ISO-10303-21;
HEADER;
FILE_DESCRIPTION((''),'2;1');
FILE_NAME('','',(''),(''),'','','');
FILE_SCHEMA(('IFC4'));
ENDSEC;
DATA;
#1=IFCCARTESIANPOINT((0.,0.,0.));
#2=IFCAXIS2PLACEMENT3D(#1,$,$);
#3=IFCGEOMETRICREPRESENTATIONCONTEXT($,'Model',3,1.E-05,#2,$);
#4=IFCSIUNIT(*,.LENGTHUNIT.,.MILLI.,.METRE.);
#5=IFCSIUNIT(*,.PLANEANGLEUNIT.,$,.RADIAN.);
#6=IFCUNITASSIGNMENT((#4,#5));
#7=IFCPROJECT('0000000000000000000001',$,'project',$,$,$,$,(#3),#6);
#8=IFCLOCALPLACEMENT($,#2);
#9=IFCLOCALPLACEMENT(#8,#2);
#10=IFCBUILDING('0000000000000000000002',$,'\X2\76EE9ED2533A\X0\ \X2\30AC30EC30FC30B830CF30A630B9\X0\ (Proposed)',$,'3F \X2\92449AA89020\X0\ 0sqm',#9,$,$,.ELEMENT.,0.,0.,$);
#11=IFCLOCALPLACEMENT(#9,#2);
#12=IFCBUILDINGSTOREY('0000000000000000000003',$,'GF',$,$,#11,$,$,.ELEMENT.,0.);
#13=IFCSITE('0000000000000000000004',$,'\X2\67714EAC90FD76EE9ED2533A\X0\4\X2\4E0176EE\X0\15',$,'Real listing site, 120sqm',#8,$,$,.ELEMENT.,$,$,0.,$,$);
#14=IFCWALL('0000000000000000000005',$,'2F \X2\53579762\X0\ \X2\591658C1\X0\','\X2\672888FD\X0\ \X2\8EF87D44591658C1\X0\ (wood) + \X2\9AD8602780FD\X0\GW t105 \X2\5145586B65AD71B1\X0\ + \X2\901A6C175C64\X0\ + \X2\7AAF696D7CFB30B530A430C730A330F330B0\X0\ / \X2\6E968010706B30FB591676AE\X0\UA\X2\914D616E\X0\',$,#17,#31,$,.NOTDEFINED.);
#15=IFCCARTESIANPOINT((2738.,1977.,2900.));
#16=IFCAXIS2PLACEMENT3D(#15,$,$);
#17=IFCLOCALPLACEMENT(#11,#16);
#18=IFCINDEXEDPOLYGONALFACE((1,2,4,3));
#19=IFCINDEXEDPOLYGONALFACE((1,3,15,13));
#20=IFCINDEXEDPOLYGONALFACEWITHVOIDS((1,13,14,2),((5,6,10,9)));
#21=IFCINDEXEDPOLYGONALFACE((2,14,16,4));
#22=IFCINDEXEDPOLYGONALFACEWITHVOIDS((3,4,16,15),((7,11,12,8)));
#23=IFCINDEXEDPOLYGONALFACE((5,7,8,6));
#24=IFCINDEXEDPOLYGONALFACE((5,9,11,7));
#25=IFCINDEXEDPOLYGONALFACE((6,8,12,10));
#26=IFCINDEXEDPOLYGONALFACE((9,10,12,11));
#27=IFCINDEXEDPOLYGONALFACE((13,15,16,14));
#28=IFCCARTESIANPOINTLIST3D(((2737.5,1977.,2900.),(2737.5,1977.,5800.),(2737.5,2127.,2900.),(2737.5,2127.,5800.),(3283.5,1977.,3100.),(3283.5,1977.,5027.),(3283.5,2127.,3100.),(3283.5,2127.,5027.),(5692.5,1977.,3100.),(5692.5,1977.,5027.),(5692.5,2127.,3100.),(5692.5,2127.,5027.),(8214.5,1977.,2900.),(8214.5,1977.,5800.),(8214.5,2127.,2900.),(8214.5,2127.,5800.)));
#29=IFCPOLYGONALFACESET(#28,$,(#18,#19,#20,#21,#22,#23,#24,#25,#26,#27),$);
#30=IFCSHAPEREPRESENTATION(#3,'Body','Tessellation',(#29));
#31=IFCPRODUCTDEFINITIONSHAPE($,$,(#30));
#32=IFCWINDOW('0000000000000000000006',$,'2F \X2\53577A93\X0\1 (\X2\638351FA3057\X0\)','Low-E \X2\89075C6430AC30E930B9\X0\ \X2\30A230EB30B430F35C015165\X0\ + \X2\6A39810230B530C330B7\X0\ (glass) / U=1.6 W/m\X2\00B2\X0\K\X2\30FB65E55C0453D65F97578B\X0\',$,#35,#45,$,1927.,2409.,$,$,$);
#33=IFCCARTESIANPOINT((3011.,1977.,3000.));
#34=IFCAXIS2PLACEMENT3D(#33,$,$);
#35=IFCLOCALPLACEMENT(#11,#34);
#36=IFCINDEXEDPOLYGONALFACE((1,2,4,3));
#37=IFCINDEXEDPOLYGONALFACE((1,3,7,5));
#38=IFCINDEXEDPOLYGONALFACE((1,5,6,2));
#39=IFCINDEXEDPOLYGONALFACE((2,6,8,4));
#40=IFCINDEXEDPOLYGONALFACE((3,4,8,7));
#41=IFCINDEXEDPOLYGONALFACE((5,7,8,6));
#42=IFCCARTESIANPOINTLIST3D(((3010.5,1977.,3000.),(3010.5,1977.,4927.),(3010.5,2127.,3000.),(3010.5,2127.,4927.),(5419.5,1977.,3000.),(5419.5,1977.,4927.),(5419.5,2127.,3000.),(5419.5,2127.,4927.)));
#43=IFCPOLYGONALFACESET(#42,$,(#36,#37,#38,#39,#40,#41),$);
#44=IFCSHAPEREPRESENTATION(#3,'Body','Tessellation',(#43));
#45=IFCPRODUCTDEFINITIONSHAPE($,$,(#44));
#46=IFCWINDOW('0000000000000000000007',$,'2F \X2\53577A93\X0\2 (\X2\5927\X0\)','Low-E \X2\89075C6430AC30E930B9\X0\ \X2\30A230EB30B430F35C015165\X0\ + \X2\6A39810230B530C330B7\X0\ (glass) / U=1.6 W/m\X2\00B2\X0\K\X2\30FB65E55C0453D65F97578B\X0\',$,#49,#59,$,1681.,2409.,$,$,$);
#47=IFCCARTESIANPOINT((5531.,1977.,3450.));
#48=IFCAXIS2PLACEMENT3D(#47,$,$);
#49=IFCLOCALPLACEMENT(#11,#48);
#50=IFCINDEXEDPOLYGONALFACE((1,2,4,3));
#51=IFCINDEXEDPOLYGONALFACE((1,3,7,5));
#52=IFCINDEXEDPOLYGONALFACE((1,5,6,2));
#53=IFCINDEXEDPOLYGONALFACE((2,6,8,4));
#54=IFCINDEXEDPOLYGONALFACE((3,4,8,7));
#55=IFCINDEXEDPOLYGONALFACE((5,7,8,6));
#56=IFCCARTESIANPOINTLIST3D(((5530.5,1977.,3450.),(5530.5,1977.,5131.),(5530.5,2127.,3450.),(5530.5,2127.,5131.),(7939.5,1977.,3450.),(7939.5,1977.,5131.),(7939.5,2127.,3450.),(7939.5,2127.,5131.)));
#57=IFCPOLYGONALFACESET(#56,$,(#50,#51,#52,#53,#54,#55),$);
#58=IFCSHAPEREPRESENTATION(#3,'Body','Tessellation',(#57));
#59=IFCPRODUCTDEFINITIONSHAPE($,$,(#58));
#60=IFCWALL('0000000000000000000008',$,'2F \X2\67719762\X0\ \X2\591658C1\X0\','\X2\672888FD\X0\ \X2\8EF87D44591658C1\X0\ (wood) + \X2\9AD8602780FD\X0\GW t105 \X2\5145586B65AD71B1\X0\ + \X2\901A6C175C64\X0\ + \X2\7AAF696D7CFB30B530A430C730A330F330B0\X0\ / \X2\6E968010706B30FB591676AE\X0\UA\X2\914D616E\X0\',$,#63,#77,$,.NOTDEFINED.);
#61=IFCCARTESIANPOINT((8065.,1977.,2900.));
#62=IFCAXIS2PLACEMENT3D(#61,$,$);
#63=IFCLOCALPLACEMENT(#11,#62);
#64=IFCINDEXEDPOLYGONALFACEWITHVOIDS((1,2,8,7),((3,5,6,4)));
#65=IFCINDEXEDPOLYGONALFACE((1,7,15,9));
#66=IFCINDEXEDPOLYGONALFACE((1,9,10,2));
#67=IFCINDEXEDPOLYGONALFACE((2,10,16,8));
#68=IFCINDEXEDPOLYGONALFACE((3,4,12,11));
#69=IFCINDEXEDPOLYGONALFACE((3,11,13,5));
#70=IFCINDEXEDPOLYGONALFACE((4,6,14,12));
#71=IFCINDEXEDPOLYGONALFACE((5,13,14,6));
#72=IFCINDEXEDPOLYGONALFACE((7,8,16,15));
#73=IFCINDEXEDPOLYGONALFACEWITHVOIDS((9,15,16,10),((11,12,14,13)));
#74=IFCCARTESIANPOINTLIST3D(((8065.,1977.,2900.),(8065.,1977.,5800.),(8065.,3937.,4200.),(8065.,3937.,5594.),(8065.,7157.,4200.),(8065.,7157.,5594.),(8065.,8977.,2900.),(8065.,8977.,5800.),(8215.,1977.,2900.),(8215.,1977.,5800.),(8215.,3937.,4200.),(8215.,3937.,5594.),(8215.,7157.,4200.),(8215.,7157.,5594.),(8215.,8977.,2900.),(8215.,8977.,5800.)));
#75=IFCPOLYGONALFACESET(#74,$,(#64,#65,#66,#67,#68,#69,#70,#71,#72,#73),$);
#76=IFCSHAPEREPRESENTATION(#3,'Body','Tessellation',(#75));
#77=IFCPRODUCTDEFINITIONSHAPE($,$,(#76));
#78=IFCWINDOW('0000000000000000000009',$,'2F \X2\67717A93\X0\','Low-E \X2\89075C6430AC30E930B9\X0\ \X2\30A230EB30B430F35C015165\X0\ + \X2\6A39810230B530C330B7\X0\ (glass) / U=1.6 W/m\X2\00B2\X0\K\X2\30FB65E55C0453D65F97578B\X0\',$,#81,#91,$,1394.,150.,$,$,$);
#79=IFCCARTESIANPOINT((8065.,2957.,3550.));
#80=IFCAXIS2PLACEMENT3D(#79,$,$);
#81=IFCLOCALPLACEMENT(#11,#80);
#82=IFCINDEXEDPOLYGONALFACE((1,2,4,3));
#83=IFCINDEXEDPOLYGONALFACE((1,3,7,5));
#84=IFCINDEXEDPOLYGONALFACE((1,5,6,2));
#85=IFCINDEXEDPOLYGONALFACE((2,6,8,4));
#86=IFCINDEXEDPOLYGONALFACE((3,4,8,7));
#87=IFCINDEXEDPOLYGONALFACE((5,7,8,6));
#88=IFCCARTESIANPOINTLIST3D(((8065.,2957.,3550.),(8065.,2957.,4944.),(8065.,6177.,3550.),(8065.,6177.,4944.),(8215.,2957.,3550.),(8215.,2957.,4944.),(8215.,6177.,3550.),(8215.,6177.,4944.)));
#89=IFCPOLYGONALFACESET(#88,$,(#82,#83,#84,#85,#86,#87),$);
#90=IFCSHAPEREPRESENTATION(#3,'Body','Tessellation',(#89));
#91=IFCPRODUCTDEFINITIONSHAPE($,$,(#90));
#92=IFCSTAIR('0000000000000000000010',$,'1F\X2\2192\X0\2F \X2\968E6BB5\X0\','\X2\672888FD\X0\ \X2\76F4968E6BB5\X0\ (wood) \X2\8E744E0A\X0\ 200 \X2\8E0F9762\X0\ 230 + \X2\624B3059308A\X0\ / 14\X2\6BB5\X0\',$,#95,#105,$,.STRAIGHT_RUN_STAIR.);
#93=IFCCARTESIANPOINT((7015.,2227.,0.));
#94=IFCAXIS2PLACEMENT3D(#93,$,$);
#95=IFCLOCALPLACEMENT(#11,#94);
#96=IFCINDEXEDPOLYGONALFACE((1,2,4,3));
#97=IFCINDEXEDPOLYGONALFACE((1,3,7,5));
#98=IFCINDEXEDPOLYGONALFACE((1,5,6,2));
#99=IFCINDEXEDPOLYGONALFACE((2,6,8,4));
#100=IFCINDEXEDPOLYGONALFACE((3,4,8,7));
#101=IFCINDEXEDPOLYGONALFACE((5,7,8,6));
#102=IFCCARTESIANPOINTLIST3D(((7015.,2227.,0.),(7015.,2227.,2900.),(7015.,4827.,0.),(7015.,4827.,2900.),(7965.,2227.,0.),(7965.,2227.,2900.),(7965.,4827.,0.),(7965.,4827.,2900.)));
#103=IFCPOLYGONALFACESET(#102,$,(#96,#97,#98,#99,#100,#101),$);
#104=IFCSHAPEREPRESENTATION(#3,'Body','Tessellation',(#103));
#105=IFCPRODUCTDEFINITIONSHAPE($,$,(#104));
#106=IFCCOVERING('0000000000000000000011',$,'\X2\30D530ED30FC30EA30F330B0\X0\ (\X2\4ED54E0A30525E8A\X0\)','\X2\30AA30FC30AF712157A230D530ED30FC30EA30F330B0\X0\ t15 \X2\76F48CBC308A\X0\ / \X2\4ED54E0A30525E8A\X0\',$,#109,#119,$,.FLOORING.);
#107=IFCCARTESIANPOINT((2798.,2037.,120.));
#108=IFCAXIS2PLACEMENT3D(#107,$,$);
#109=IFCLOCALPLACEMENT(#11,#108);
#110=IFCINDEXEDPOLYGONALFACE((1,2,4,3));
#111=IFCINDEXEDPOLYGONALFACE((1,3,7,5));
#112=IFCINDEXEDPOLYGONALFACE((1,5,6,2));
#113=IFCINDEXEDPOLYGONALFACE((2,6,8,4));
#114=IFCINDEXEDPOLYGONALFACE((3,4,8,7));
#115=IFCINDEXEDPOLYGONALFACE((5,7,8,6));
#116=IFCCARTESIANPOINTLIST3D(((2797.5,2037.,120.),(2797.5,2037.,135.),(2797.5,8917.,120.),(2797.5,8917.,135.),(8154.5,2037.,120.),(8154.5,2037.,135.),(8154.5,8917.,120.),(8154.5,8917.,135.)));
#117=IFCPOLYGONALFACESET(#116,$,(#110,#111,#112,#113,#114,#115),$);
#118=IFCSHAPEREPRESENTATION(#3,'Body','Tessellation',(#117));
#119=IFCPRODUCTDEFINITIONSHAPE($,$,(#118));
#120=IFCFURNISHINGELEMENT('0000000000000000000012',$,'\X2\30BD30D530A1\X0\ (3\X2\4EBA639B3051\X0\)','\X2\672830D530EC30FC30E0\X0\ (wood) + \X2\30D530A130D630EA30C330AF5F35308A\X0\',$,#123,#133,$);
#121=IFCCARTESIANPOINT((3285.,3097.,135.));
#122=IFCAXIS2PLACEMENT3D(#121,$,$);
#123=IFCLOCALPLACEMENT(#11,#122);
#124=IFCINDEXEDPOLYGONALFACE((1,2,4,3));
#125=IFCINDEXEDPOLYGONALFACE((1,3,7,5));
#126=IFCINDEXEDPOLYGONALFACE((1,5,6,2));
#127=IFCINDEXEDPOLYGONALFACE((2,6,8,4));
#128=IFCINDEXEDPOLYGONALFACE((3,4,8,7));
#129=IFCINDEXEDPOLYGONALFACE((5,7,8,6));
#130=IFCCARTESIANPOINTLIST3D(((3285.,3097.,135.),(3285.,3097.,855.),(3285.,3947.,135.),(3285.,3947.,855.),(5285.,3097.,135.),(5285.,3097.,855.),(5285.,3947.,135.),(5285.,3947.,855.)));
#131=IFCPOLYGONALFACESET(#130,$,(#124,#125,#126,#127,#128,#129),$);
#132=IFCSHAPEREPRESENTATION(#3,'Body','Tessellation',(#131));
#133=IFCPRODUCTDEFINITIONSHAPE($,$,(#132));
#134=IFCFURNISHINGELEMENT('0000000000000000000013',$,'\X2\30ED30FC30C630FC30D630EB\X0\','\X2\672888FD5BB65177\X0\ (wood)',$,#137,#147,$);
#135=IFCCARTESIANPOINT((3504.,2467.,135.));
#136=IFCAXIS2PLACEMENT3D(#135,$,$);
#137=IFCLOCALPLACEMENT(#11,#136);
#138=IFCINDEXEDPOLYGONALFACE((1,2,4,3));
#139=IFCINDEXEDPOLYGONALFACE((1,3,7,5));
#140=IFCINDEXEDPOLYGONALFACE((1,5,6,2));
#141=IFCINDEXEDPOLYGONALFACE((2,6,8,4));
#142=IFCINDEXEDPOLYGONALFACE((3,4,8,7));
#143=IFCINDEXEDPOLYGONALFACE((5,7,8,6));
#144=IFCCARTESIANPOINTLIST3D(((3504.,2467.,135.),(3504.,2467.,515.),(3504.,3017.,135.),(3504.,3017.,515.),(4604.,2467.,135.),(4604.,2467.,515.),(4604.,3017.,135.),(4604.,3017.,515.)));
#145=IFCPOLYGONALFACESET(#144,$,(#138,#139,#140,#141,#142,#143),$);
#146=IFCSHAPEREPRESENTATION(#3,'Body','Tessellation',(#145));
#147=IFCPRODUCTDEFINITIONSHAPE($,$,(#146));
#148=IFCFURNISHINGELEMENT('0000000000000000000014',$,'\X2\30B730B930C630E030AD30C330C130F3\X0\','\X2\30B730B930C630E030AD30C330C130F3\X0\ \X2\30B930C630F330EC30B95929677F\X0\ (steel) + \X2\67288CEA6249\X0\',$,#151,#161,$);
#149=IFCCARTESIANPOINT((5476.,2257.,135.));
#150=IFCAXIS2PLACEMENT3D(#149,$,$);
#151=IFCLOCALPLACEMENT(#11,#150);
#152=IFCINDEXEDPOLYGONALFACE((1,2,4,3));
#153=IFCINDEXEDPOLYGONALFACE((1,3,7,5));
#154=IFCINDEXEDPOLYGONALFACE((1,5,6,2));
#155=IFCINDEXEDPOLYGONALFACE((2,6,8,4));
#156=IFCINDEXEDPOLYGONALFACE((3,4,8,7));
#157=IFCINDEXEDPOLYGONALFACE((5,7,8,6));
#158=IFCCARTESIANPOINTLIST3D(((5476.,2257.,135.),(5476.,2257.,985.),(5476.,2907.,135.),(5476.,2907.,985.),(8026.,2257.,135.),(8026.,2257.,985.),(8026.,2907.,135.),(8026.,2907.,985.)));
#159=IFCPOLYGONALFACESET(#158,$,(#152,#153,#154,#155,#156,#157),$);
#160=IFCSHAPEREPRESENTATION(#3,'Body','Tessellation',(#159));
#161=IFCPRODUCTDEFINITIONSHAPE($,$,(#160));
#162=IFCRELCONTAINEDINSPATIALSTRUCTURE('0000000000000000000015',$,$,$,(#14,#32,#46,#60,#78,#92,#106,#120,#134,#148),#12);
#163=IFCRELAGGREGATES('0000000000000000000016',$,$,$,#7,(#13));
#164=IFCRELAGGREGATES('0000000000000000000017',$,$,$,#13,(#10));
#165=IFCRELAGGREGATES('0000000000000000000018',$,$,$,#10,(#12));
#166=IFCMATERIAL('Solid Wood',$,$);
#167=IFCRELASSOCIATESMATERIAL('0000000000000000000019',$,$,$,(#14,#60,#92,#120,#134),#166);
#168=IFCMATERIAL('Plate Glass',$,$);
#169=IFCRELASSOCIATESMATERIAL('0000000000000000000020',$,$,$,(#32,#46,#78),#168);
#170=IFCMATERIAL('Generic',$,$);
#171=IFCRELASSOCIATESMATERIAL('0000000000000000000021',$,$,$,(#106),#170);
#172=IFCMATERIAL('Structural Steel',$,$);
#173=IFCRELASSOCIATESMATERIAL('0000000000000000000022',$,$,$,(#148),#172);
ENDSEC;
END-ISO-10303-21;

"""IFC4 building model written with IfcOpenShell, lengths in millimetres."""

from ifc_helpers import new_model, si_unit, frame, frame_2d, origin, place, context, project, spatial, rectangle, extrude, material, element, fill, save


model = new_model("IFC4")

# Units and contexts
model_context = context("Model", 3, precision=1e-05, world=origin())
ifc_project = project(units=[si_unit("LENGTHUNIT", "METRE", prefix="MILLI"), si_unit("PLANEANGLEUNIT", "RADIAN")], contexts=[model_context])

# Site, building, storey
site_placement = place(None, origin())
site = spatial("IfcSite", under=ifc_project, at=site_placement, Name="東京都目黒区4丁目15", ObjectType="Real listing site, 120sqm", CompositionType="ELEMENT", RefElevation=0.0)
building_placement = place(site_placement, origin())
building = spatial("IfcBuilding", under=site, at=building_placement, Name="目黒区 ガレージハウス (Proposed)", ObjectType="3F 鉄骨造 0sqm", CompositionType="ELEMENT", ElevationOfRefHeight=0.0, ElevationOfTerrain=0.0)
storey_placement = place(building_placement, origin())
storey = spatial("IfcBuildingStorey", under=building, at=storey_placement, Name="GF", CompositionType="ELEMENT", Elevation=0.0)

# Shared definitions
ifc_material_1 = material(Name="Solid Wood")

# Shared definitions
ifc_material_2 = material(Name="Plate Glass")

# Wall, openings, windows
wall_1_placement = place(storey_placement, frame((2738.0, 1977.0, 2900.0)))
wall_1 = element("IfcWall", 1, at=wall_1_placement, inside=storey, material=ifc_material_1, Name="2F 南面 外壁", Description="木製 軸組外壁 (wood) + 高性能GW t105 充填断熱 + 通気層 + 窯業系サイディング / 準耐火・外皮UA配慮", PredefinedType="NOTDEFINED", context=model_context, shape_type="SweptSolid", body=[
    extrude(rectangle(XDim=5477.0, YDim=150.0, at=frame_2d((2738.0, 75.0))), frame((2738.0, 1977.0, 2900.0)), (0.0, 0.0, 1.0), 2900.0),
])
opening_1_placement = place(storey_placement, frame((3011.0, 1977.0, 3000.0)))
opening_1 = element("IfcOpeningElement", 2, at=opening_1_placement, cuts=wall_1, PredefinedType="NOTDEFINED", context=model_context, shape_type="SweptSolid", body=[
    extrude(rectangle(XDim=2409.0, YDim=150.0, at=frame_2d((1204.0, 75.0))), frame((3011.0, 1977.0, 3000.0)), (0.0, 0.0, 1.0), 1927.0),
])
opening_2_placement = place(storey_placement, frame((5531.0, 1977.0, 3450.0)))
opening_2 = element("IfcOpeningElement", 3, at=opening_2_placement, cuts=wall_1, PredefinedType="NOTDEFINED", context=model_context, shape_type="SweptSolid", body=[
    extrude(rectangle(XDim=2409.0, YDim=150.0, at=frame_2d((1204.0, 75.0))), frame((5531.0, 1977.0, 3450.0)), (0.0, 0.0, 1.0), 1681.0),
])
window_1_placement = place(storey_placement, frame((3011.0, 1977.0, 3000.0)))
window_1 = element("IfcWindow", 4, at=window_1_placement, inside=storey, material=ifc_material_2, Name="2F 南窓1 (掃出し)", Description="Low-E 複層ガラス アルゴン封入 + 樹脂サッシ (glass) / U=1.6 W/m²K・日射取得型", OverallHeight=1927.0, OverallWidth=2409.0, context=model_context, shape_type="SweptSolid", body=[
    extrude(rectangle(XDim=2409.0, YDim=150.0, at=frame_2d((1204.0, 75.0))), frame((3011.0, 1977.0, 3000.0)), (0.0, 0.0, 1.0), 1927.0),
])
fill(opening_1, window_1)
window_2_placement = place(storey_placement, frame((5531.0, 1977.0, 3450.0)))
window_2 = element("IfcWindow", 5, at=window_2_placement, inside=storey, material=ifc_material_2, Name="2F 南窓2 (大)", Description="Low-E 複層ガラス アルゴン封入 + 樹脂サッシ (glass) / U=1.6 W/m²K・日射取得型", OverallHeight=1681.0, OverallWidth=2409.0, context=model_context, shape_type="SweptSolid", body=[
    extrude(rectangle(XDim=2409.0, YDim=150.0, at=frame_2d((1204.0, 75.0))), frame((5531.0, 1977.0, 3450.0)), (0.0, 0.0, 1.0), 1681.0),
])
fill(opening_2, window_2)

# Wall, opening, window
wall_2_placement = place(storey_placement, frame((8065.0, 1977.0, 2900.0)))
wall_2 = element("IfcWall", 6, at=wall_2_placement, inside=storey, material=ifc_material_1, Name="2F 東面 外壁", Description="木製 軸組外壁 (wood) + 高性能GW t105 充填断熱 + 通気層 + 窯業系サイディング / 準耐火・外皮UA配慮", PredefinedType="NOTDEFINED", context=model_context, shape_type="SweptSolid", body=[
    extrude(rectangle(XDim=150.0, YDim=7000.0, at=frame_2d((75.0, 3500.0))), frame((8065.0, 1977.0, 2900.0)), (0.0, 0.0, 1.0), 2900.0),
])
opening_3_placement = place(storey_placement, frame((8065.0, 2957.0, 3550.0)))
opening_3 = element("IfcOpeningElement", 7, at=opening_3_placement, cuts=wall_2, PredefinedType="NOTDEFINED", context=model_context, shape_type="SweptSolid", body=[
    extrude(rectangle(XDim=150.0, YDim=3220.0, at=frame_2d((75.0, 1610.0))), frame((8065.0, 2957.0, 3550.0)), (0.0, 0.0, 1.0), 1394.0),
])
window_3_placement = place(storey_placement, frame((8065.0, 2957.0, 3550.0)))
window_3 = element("IfcWindow", 8, at=window_3_placement, inside=storey, material=ifc_material_2, Name="2F 東窓", Description="Low-E 複層ガラス アルゴン封入 + 樹脂サッシ (glass) / U=1.6 W/m²K・日射取得型", OverallHeight=1394.0, OverallWidth=150.0, context=model_context, shape_type="SweptSolid", body=[
    extrude(rectangle(XDim=150.0, YDim=3220.0, at=frame_2d((75.0, 1610.0))), frame((8065.0, 2957.0, 3550.0)), (0.0, 0.0, 1.0), 1394.0),
])
fill(opening_3, window_3)

# Stair
stair_placement = place(storey_placement, frame((7015.0, 2227.0, 0.0)))
element("IfcStair", 9, at=stair_placement, inside=storey, material=ifc_material_1, Name="1F→2F 階段", Description="木製 直階段 (wood) 蹴上 200 踏面 230 + 手すり / 14段", PredefinedType="STRAIGHT_RUN_STAIR", context=model_context, shape_type="SweptSolid", body=[
    extrude(rectangle(XDim=950.0, YDim=2600.0, at=frame_2d((475.0, 1300.0))), frame((7015.0, 2227.0, 0.0)), (0.0, 0.0, 1.0), 2900.0),
])

# Covering
ifc_material_3 = material(Name="Generic")
covering_placement = place(storey_placement, frame((2798.0, 2037.0, 120.0)))
element("IfcCovering", 10, at=covering_placement, inside=storey, material=ifc_material_3, Name="フローリング (仕上げ床)", Description="オーク無垢フローリング t15 直貼り / 仕上げ床", PredefinedType="FLOORING", context=model_context, shape_type="SweptSolid", body=[
    extrude(rectangle(XDim=5357.0, YDim=6880.0, at=frame_2d((2678.0, 3440.0))), frame((2798.0, 2037.0, 120.0)), (0.0, 0.0, 1.0), 15.0),
])

# Furnishing elements
furnishing_1_placement = place(storey_placement, frame((3285.0, 3097.0, 135.0)))
element("IfcFurnishingElement", 11, at=furnishing_1_placement, inside=storey, material=ifc_material_1, Name="ソファ (3人掛け)", Description="木フレーム (wood) + ファブリック張り", context=model_context, shape_type="SweptSolid", body=[
    extrude(rectangle(XDim=2000.0, YDim=850.0, at=frame_2d((1000.0, 425.0))), frame((3285.0, 3097.0, 135.0)), (0.0, 0.0, 1.0), 720.0),
])
furnishing_2_placement = place(storey_placement, frame((3504.0, 2467.0, 135.0)))
element("IfcFurnishingElement", 12, at=furnishing_2_placement, inside=storey, material=ifc_material_1, Name="ローテーブル", Description="木製家具 (wood)", context=model_context, shape_type="SweptSolid", body=[
    extrude(rectangle(XDim=1100.0, YDim=550.0, at=frame_2d((550.0, 275.0))), frame((3504.0, 2467.0, 135.0)), (0.0, 0.0, 1.0), 380.0),
])
ifc_material_4 = material(Name="Structural Steel")
furnishing_3_placement = place(storey_placement, frame((5476.0, 2257.0, 135.0)))
element("IfcFurnishingElement", 13, at=furnishing_3_placement, inside=storey, material=ifc_material_4, Name="システムキッチン", Description="システムキッチン ステンレス天板 (steel) + 木質扉", context=model_context, shape_type="SweptSolid", body=[
    extrude(rectangle(XDim=2550.0, YDim=650.0, at=frame_2d((1275.0, 325.0))), frame((5476.0, 2257.0, 135.0)), (0.0, 0.0, 1.0), 850.0),
])

save(model, "model.ifc")
